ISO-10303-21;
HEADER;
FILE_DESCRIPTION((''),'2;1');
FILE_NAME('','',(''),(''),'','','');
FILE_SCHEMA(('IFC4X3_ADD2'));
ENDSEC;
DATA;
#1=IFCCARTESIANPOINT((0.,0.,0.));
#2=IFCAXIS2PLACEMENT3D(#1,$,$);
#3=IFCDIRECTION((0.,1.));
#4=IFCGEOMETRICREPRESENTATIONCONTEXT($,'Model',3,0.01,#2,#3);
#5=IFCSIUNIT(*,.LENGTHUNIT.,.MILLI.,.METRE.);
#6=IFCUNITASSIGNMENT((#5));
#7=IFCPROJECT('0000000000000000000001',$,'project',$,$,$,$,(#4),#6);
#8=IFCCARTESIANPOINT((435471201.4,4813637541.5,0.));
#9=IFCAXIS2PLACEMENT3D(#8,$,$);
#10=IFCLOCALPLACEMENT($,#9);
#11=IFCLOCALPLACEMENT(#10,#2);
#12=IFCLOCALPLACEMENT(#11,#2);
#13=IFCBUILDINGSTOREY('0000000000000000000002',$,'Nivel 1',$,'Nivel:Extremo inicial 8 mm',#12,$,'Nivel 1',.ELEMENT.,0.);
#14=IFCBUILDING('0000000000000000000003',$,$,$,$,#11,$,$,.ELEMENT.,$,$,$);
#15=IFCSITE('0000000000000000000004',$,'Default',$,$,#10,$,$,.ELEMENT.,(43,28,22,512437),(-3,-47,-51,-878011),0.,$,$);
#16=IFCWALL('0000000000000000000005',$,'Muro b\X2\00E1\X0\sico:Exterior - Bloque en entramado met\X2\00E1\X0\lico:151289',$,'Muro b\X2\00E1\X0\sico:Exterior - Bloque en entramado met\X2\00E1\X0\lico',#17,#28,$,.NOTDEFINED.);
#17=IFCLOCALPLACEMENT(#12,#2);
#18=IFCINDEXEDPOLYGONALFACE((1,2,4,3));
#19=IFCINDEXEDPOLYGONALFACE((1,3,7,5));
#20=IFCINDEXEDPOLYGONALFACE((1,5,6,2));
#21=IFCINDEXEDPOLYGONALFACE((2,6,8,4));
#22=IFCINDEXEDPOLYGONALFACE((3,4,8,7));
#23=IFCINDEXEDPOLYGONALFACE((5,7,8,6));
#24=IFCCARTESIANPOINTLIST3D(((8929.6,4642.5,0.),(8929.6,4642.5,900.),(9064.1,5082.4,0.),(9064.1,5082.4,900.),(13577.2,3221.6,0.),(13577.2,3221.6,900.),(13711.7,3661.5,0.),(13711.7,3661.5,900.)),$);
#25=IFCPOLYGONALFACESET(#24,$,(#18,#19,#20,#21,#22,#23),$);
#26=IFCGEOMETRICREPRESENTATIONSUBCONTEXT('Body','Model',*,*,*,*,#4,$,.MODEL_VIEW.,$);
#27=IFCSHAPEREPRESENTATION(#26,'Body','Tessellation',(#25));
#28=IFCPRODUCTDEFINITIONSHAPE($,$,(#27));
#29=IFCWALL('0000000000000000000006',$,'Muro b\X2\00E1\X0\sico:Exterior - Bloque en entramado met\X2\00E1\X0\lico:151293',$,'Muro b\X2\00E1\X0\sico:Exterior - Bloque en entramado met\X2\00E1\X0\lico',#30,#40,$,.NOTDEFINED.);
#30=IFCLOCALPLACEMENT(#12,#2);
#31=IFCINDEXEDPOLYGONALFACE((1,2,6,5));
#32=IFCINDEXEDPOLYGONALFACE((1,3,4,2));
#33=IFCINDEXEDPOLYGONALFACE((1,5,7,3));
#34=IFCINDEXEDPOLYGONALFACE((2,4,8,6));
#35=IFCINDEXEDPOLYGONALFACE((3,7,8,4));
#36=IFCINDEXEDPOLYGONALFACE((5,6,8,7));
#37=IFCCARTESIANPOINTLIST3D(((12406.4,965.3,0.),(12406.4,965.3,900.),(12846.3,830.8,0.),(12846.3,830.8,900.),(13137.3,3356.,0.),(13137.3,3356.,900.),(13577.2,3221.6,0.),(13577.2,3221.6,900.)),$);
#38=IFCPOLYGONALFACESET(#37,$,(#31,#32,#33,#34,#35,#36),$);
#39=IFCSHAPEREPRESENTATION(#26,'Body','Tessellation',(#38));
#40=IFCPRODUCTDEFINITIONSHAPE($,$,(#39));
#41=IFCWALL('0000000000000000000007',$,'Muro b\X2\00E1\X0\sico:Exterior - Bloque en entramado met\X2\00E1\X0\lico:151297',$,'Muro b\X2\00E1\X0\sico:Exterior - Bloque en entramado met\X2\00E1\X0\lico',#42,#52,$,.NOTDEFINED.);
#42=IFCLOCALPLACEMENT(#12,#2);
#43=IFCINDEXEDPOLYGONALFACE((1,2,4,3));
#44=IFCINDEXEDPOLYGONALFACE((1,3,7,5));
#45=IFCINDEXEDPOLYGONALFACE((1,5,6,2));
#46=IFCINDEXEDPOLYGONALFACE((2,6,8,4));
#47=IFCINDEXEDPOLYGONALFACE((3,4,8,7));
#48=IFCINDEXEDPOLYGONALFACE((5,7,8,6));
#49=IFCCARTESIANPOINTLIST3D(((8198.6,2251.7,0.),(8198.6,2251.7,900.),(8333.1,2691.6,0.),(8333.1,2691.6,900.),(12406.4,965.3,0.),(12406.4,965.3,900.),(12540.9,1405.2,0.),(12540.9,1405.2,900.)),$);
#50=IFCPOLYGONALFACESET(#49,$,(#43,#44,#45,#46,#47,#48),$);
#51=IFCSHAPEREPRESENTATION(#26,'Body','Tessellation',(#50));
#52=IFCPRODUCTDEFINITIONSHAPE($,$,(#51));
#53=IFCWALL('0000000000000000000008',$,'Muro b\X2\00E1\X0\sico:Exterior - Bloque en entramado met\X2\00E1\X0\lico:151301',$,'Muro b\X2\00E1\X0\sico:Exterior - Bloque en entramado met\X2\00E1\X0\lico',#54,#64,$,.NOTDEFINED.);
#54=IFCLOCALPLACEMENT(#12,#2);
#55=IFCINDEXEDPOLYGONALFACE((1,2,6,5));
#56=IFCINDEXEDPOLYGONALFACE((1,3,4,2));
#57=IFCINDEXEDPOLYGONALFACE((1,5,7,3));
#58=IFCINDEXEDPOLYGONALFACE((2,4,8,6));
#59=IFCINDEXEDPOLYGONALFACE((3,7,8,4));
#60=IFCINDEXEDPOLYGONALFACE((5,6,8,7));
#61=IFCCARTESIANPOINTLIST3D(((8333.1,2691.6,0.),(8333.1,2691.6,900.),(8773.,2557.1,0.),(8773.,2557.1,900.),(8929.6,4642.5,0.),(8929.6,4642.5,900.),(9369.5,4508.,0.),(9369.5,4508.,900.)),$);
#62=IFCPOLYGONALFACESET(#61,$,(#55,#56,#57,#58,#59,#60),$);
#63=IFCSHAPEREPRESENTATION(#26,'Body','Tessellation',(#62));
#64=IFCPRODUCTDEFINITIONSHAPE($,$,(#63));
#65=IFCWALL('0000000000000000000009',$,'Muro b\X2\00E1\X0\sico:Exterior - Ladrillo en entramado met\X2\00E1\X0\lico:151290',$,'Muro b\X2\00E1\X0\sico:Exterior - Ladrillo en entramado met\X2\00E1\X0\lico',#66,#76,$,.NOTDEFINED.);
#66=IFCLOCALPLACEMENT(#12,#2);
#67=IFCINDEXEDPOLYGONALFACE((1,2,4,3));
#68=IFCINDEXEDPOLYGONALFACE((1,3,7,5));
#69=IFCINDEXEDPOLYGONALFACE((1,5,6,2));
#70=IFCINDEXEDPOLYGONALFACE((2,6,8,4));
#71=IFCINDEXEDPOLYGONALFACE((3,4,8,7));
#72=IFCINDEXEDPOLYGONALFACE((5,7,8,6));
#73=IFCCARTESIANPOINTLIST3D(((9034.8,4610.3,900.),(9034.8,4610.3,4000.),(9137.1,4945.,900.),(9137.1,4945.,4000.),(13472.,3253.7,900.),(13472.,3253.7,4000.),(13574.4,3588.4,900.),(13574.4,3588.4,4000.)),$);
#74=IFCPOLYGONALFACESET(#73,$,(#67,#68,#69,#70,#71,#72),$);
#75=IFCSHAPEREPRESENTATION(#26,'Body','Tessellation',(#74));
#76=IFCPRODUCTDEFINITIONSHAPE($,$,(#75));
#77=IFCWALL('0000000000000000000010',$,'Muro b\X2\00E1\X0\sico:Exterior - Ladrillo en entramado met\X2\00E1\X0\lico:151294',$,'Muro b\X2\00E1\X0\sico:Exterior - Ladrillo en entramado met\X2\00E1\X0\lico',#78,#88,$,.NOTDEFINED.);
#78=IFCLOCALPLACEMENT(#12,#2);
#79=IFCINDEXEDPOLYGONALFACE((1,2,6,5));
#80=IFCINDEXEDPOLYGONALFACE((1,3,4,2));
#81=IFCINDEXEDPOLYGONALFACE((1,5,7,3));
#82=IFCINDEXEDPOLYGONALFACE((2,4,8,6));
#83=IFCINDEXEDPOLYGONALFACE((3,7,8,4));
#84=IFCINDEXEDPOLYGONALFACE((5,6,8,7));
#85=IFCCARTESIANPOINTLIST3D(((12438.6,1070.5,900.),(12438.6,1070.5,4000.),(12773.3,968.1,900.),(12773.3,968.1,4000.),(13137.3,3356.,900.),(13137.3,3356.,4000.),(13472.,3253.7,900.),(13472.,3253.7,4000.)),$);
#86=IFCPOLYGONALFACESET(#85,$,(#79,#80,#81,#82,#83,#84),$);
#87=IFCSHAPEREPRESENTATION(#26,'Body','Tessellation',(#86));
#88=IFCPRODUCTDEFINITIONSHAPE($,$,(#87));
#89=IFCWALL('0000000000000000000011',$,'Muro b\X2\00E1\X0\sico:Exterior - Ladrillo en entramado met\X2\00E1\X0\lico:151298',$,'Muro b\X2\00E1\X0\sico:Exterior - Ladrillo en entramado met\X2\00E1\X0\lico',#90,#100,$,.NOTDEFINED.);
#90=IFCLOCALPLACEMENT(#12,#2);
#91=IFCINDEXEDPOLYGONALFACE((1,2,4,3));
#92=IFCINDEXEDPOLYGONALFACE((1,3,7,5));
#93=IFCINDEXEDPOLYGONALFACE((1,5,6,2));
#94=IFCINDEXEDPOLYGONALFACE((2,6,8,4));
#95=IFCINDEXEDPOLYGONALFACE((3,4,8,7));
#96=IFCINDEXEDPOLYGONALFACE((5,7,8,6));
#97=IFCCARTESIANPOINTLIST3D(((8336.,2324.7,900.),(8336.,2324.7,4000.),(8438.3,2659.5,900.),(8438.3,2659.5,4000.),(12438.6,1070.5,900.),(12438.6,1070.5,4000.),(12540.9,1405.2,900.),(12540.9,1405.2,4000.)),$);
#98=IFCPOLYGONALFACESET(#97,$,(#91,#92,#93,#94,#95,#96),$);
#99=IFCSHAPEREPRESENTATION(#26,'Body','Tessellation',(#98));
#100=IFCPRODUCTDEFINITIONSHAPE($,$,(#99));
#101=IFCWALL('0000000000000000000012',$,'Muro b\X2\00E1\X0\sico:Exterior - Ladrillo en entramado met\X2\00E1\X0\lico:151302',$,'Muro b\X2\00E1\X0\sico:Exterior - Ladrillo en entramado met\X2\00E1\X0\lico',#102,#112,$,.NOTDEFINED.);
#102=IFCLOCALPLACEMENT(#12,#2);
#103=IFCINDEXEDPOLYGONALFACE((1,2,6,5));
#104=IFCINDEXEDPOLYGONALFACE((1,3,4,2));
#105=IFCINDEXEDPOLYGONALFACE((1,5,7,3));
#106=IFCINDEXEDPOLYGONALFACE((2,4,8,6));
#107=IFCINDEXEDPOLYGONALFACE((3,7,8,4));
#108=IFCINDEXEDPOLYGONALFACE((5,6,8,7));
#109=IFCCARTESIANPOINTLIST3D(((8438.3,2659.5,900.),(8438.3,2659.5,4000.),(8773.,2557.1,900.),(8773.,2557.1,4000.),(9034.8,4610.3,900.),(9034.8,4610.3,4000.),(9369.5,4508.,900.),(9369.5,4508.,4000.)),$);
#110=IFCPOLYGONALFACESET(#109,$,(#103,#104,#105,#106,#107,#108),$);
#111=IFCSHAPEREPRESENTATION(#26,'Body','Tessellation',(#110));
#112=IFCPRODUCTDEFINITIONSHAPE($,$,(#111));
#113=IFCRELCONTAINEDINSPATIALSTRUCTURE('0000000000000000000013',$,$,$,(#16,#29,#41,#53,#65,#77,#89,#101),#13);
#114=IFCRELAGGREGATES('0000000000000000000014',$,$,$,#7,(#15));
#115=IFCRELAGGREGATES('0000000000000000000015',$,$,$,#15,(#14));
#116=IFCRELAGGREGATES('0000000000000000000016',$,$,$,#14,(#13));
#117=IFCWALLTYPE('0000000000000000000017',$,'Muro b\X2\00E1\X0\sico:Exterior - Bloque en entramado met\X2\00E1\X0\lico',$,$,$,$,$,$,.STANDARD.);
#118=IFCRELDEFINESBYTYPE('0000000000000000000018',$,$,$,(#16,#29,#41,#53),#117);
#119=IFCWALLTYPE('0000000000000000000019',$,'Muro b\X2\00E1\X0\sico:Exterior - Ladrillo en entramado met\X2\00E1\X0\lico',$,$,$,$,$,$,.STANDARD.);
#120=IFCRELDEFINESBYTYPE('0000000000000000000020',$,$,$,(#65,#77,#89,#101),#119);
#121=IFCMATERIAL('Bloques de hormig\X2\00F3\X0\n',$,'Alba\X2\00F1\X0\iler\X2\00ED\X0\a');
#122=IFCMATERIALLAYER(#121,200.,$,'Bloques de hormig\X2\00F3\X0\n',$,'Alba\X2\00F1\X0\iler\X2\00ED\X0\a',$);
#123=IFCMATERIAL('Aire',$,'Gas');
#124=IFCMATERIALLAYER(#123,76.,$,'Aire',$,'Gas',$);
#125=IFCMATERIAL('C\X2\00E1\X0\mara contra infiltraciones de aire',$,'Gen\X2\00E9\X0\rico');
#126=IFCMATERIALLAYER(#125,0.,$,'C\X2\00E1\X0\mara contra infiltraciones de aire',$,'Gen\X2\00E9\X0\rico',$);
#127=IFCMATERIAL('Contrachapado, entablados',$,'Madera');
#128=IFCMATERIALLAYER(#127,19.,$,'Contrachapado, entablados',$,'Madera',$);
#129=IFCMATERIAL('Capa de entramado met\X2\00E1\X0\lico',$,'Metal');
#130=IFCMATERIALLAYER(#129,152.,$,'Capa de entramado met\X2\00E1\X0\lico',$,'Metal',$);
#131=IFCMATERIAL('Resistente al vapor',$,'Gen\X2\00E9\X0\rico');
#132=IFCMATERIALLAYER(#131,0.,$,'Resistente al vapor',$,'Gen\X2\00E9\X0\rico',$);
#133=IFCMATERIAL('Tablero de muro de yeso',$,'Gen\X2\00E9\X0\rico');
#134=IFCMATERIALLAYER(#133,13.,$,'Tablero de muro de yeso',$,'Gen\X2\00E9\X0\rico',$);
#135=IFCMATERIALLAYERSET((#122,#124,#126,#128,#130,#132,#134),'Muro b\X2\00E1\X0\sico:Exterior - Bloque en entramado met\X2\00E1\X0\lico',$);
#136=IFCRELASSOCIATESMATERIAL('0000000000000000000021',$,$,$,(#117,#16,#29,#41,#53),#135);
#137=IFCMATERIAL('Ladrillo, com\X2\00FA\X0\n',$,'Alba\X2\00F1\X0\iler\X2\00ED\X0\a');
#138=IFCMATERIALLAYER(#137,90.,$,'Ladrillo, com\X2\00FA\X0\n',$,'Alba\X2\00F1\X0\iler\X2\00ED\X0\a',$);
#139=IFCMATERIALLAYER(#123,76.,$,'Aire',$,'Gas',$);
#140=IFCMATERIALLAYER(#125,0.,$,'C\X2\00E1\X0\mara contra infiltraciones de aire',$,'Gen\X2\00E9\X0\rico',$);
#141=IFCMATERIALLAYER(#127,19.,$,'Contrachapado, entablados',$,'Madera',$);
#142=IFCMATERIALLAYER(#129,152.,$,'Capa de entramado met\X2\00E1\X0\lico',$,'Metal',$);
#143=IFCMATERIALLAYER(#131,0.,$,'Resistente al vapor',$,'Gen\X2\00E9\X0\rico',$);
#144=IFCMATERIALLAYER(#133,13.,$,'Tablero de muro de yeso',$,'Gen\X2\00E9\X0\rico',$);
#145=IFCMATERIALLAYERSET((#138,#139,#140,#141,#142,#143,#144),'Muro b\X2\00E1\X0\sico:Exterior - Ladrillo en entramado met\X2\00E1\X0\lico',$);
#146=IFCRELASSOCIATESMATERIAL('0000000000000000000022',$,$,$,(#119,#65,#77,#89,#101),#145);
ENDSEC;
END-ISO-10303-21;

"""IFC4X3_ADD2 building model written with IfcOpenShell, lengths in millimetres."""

from ifc_helpers import new_model, si_unit, direction, frame, frame_2d, origin, place, context, subcontext, project, spatial, rectangle, extrude, material, layer, layer_set, type_object, element, save


model = new_model("IFC4X3_ADD2")

# Units and contexts
model_context = context("Model", 3, precision=0.01, world=origin(), true_north=direction((0.0, 1.0)))
body_context = subcontext(model_context, "Body", "Model", "MODEL_VIEW")
ifc_project = project(units=[si_unit("LENGTHUNIT", "METRE", prefix="MILLI")], contexts=[model_context])

# Site, building, storey
site_placement = place(None, frame((435471201.4, 4813637541.5, 0.0)))
site = spatial("IfcSite", under=ifc_project, at=site_placement, Name="Default", CompositionType="ELEMENT", RefLatitude=(43, 28, 22, 512437), RefLongitude=(-3, -47, -51, -878011), RefElevation=0.0)
building_placement = place(site_placement, origin())
building = spatial("IfcBuilding", under=site, at=building_placement, CompositionType="ELEMENT")
storey_placement = place(building_placement, origin())
storey = spatial("IfcBuildingStorey", under=building, at=storey_placement, Name="Nivel 1", ObjectType="Nivel:Extremo inicial 8 mm", LongName="Nivel 1", CompositionType="ELEMENT", Elevation=0.0)

# Walls
ifc_material_1 = material(Name="Bloques de hormigón", Category="Albañilería")
ifc_layer_1 = layer(ifc_material_1, 200.0, Name="Bloques de hormigón", Category="Albañilería")
ifc_material_2 = material(Name="Aire", Category="Gas")
ifc_layer_2 = layer(ifc_material_2, 76.0, Name="Aire", Category="Gas")
ifc_material_3 = material(Name="Cámara contra infiltraciones de aire", Category="Genérico")
ifc_layer_3 = layer(ifc_material_3, 0.0, Name="Cámara contra infiltraciones de aire", Category="Genérico")
ifc_material_4 = material(Name="Contrachapado, entablados", Category="Madera")
ifc_layer_4 = layer(ifc_material_4, 19.0, Name="Contrachapado, entablados", Category="Madera")
ifc_material_5 = material(Name="Capa de entramado metálico", Category="Metal")
ifc_layer_5 = layer(ifc_material_5, 152.0, Name="Capa de entramado metálico", Category="Metal")
ifc_material_6 = material(Name="Resistente al vapor", Category="Genérico")
ifc_layer_6 = layer(ifc_material_6, 0.0, Name="Resistente al vapor", Category="Genérico")
ifc_material_7 = material(Name="Tablero de muro de yeso", Category="Genérico")
ifc_layer_7 = layer(ifc_material_7, 13.0, Name="Tablero de muro de yeso", Category="Genérico")
ifc_layer_set_1 = layer_set([ifc_layer_1, ifc_layer_2, ifc_layer_3, ifc_layer_4, ifc_layer_5, ifc_layer_6, ifc_layer_7], Name="Muro básico:Exterior - Bloque en entramado metálico")
wall_type_1 = type_object("IfcWallType", Name="Muro básico:Exterior - Bloque en entramado metálico", PredefinedType="STANDARD", material=ifc_layer_set_1)
wall_1_placement = place(storey_placement, frame((8996.8, 4862.4, 0.0), z_axis=(0.0, 0.0, 1.0), x_axis=(0.956305, -0.292372, 0.0)))
element("IfcWall", 1, at=wall_1_placement, inside=storey, type_object=wall_type_1, material=ifc_layer_set_1, Name="Muro básico:Exterior - Bloque en entramado metálico:151289", ObjectType="Muro básico:Exterior - Bloque en entramado metálico", PredefinedType="NOTDEFINED", context=body_context, shape_type="SweptSolid", body=[
    extrude(rectangle(XDim=4860.0, YDim=460.0, at=frame_2d((2430.0, 0.0), x_axis=(-1.0, 0.0))), origin(), (0.0, 0.0, 1.0), 900.0),
])
wall_2_placement = place(storey_placement, frame((13357.3, 3288.8, 0.0), z_axis=(0.0, 0.0, 1.0), x_axis=(-0.292372, -0.956305, 0.0)))
element("IfcWall", 2, at=wall_2_placement, inside=storey, type_object=wall_type_1, material=ifc_layer_set_1, Name="Muro básico:Exterior - Bloque en entramado metálico:151293", ObjectType="Muro básico:Exterior - Bloque en entramado metálico", PredefinedType="NOTDEFINED", context=body_context, shape_type="SweptSolid", body=[
    extrude(rectangle(XDim=2500.0, YDim=460.0, at=frame_2d((1250.0, 0.0), x_axis=(-1.0, 0.0))), origin(), (0.0, 0.0, 1.0), 900.0),
])
wall_3_placement = place(storey_placement, frame((12473.6, 1185.2, 0.0), z_axis=(0.0, 0.0, 1.0), x_axis=(-0.956305, 0.292372, 0.0)))
element("IfcWall", 3, at=wall_3_placement, inside=storey, type_object=wall_type_1, material=ifc_layer_set_1, Name="Muro básico:Exterior - Bloque en entramado metálico:151297", ObjectType="Muro básico:Exterior - Bloque en entramado metálico", PredefinedType="NOTDEFINED", context=body_context, shape_type="SweptSolid", body=[
    extrude(rectangle(XDim=4400.0, YDim=460.0, at=frame_2d((2200.0, 0.0), x_axis=(-1.0, 0.0))), origin(), (0.0, 0.0, 1.0), 900.0),
])
wall_4_placement = place(storey_placement, frame((8553.1, 2624.4, 0.0), z_axis=(0.0, 0.0, 1.0), x_axis=(0.292372, 0.956305, 0.0)))
element("IfcWall", 4, at=wall_4_placement, inside=storey, type_object=wall_type_1, material=ifc_layer_set_1, Name="Muro básico:Exterior - Bloque en entramado metálico:151301", ObjectType="Muro básico:Exterior - Bloque en entramado metálico", PredefinedType="NOTDEFINED", context=body_context, shape_type="SweptSolid", body=[
    extrude(rectangle(XDim=2040.0, YDim=460.0, at=frame_2d((1020.0, 0.0), x_axis=(-1.0, 0.0))), origin(), (0.0, 0.0, 1.0), 900.0),
])
ifc_material_8 = material(Name="Ladrillo, común", Category="Albañilería")
ifc_layer_8 = layer(ifc_material_8, 90.0, Name="Ladrillo, común", Category="Albañilería")
ifc_layer_9 = layer(ifc_material_2, 76.0, Name="Aire", Category="Gas")
ifc_layer_10 = layer(ifc_material_3, 0.0, Name="Cámara contra infiltraciones de aire", Category="Genérico")
ifc_layer_11 = layer(ifc_material_4, 19.0, Name="Contrachapado, entablados", Category="Madera")
ifc_layer_12 = layer(ifc_material_5, 152.0, Name="Capa de entramado metálico", Category="Metal")
ifc_layer_13 = layer(ifc_material_6, 0.0, Name="Resistente al vapor", Category="Genérico")
ifc_layer_14 = layer(ifc_material_7, 13.0, Name="Tablero de muro de yeso", Category="Genérico")
ifc_layer_set_2 = layer_set([ifc_layer_8, ifc_layer_9, ifc_layer_10, ifc_layer_11, ifc_layer_12, ifc_layer_13, ifc_layer_14], Name="Muro básico:Exterior - Ladrillo en entramado metálico")
wall_type_2 = type_object("IfcWallType", Name="Muro básico:Exterior - Ladrillo en entramado metálico", PredefinedType="STANDARD", material=ifc_layer_set_2)
wall_5_placement = place(storey_placement, frame((9085.9, 4777.7, 900.0), z_axis=(0.0, 0.0, 1.0), x_axis=(0.956305, -0.292372, 0.0)))
element("IfcWall", 5, at=wall_5_placement, inside=storey, type_object=wall_type_2, material=ifc_layer_set_2, Name="Muro básico:Exterior - Ladrillo en entramado metálico:151290", ObjectType="Muro básico:Exterior - Ladrillo en entramado metálico", PredefinedType="NOTDEFINED", context=body_context, shape_type="SweptSolid", body=[
    extrude(rectangle(XDim=4640.0, YDim=350.0, at=frame_2d((2320.0, 0.0), x_axis=(-1.0, 0.0))), origin(), (0.0, 0.0, 1.0), 3100.0),
])
wall_6_placement = place(storey_placement, frame((13304.7, 3304.9, 900.0), z_axis=(0.0, 0.0, 1.0), x_axis=(-0.292372, -0.956305, 0.0)))
element("IfcWall", 6, at=wall_6_placement, inside=storey, type_object=wall_type_2, material=ifc_layer_set_2, Name="Muro básico:Exterior - Ladrillo en entramado metálico:151294", ObjectType="Muro básico:Exterior - Ladrillo en entramado metálico", PredefinedType="NOTDEFINED", context=body_context, shape_type="SweptSolid", body=[
    extrude(rectangle(XDim=2390.0, YDim=350.0, at=frame_2d((1195.0, 0.0), x_axis=(-1.0, 0.0))), origin(), (0.0, 0.0, 1.0), 3100.0),
])
wall_7_placement = place(storey_placement, frame((12489.7, 1237.8, 900.0), z_axis=(0.0, 0.0, 1.0), x_axis=(-0.956305, 0.292372, 0.0)))
element("IfcWall", 7, at=wall_7_placement, inside=storey, type_object=wall_type_2, material=ifc_layer_set_2, Name="Muro básico:Exterior - Ladrillo en entramado metálico:151298", ObjectType="Muro básico:Exterior - Ladrillo en entramado metálico", PredefinedType="NOTDEFINED", context=body_context, shape_type="SweptSolid", body=[
    extrude(rectangle(XDim=4290.0, YDim=350.0, at=frame_2d((2145.0, 0.0), x_axis=(-1.0, 0.0))), origin(), (0.0, 0.0, 1.0), 3100.0),
])
wall_8_placement = place(storey_placement, frame((8605.7, 2608.3, 900.0), z_axis=(0.0, 0.0, 1.0), x_axis=(0.292372, 0.956305, 0.0)))
element("IfcWall", 8, at=wall_8_placement, inside=storey, type_object=wall_type_2, material=ifc_layer_set_2, Name="Muro básico:Exterior - Ladrillo en entramado metálico:151302", ObjectType="Muro básico:Exterior - Ladrillo en entramado metálico", PredefinedType="NOTDEFINED", context=body_context, shape_type="SweptSolid", body=[
    extrude(rectangle(XDim=2040.0, YDim=350.0, at=frame_2d((1020.0, 0.0), x_axis=(-1.0, 0.0))), origin(), (0.0, 0.0, 1.0), 3100.0),
])

save(model, "model.ifc")
